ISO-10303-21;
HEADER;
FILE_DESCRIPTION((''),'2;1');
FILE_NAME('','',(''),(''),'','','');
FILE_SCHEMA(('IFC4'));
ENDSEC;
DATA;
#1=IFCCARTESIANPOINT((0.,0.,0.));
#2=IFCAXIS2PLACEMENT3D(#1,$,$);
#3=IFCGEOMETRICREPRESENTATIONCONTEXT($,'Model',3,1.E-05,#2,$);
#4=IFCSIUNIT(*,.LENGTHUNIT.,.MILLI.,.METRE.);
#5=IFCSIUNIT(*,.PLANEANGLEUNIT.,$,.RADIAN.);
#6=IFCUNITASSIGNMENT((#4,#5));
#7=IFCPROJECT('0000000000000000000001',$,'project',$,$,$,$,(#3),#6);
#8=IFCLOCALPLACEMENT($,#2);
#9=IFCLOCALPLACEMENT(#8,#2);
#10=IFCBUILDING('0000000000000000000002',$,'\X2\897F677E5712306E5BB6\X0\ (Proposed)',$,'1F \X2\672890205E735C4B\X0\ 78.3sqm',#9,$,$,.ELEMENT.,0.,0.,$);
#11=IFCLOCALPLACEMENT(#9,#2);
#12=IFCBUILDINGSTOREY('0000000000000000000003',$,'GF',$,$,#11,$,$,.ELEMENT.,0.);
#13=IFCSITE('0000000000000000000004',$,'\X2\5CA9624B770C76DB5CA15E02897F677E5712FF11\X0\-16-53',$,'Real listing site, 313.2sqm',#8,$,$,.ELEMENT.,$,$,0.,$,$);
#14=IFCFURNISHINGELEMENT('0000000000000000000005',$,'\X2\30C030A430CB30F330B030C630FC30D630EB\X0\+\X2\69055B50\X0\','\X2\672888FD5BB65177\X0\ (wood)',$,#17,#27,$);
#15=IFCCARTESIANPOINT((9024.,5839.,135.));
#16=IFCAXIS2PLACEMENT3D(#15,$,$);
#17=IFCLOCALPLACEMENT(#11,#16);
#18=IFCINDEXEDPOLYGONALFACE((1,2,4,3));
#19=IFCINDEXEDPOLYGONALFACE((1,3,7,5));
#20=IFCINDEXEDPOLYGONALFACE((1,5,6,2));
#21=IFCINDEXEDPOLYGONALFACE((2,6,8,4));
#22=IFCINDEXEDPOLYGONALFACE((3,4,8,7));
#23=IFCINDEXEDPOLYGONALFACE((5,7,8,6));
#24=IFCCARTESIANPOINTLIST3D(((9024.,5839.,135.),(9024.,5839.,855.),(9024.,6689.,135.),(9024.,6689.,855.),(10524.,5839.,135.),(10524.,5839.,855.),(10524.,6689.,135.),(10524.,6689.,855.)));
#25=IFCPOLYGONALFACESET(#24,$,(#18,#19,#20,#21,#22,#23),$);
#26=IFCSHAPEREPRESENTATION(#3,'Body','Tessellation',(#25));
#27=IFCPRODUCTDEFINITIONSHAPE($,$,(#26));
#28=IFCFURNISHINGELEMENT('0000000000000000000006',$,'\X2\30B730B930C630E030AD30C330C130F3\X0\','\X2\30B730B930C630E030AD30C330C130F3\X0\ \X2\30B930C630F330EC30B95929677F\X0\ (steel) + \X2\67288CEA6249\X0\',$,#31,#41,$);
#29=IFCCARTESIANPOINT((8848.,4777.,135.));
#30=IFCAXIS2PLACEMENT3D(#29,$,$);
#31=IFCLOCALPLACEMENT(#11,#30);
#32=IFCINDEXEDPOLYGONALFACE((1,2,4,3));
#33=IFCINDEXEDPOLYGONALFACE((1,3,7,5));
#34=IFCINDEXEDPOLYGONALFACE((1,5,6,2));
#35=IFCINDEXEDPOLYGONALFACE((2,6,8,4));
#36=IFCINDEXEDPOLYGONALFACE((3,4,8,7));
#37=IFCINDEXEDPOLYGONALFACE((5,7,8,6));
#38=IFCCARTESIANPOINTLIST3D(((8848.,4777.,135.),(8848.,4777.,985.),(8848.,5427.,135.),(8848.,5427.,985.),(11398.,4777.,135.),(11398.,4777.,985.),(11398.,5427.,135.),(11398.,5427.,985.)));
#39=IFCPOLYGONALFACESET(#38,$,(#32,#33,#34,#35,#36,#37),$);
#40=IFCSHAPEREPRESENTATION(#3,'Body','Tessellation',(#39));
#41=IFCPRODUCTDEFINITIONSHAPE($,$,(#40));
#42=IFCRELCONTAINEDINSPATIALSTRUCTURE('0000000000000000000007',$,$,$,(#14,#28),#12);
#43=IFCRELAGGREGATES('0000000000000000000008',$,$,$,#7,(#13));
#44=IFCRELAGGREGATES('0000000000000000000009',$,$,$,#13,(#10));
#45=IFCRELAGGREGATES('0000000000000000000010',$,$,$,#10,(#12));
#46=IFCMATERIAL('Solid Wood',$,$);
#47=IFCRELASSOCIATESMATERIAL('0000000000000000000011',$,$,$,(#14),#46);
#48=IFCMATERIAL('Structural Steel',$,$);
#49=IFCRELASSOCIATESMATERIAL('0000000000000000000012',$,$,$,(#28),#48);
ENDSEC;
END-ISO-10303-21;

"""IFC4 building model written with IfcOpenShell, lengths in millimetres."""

from ifc_helpers import new_model, si_unit, frame, frame_2d, origin, place, context, project, spatial, rectangle, extrude, material, element, save


model = new_model("IFC4")

# Units and contexts
model_context = context("Model", 3, precision=1e-05, world=origin())
ifc_project = project(units=[si_unit("LENGTHUNIT", "METRE", prefix="MILLI"), si_unit("PLANEANGLEUNIT", "RADIAN")], contexts=[model_context])

# Site, building, storey
site_placement = place(None, origin())
site = spatial("IfcSite", under=ifc_project, at=site_placement, Name="岩手県盛岡市西松園１-16-53", ObjectType="Real listing site, 313.2sqm", CompositionType="ELEMENT", RefElevation=0.0)
building_placement = place(site_placement, origin())
building = spatial("IfcBuilding", under=site, at=building_placement, Name="西松園の家 (Proposed)", ObjectType="1F 木造平屋 78.3sqm", CompositionType="ELEMENT", ElevationOfRefHeight=0.0, ElevationOfTerrain=0.0)
storey_placement = place(building_placement, origin())
storey = spatial("IfcBuildingStorey", under=building, at=storey_placement, Name="GF", CompositionType="ELEMENT", Elevation=0.0)

# Shared definitions
ifc_material_1 = material(Name="Solid Wood")

# Shared definitions
ifc_material_2 = material(Name="Structural Steel")

# Furnishing elements
furnishing_1_placement = place(storey_placement, frame((9024.0, 5839.0, 135.0)))
element("IfcFurnishingElement", 1, at=furnishing_1_placement, inside=storey, material=ifc_material_1, Name="ダイニングテーブル+椅子", Description="木製家具 (wood)", context=model_context, shape_type="SweptSolid", body=[
    extrude(rectangle(XDim=1500.0, YDim=850.0, at=frame_2d((750.0, 425.0))), frame((9024.0, 5839.0, 135.0)), (0.0, 0.0, 1.0), 720.0),
])
furnishing_2_placement = place(storey_placement, frame((8848.0, 4777.0, 135.0)))
element("IfcFurnishingElement", 2, at=furnishing_2_placement, inside=storey, material=ifc_material_2, Name="システムキッチン", Description="システムキッチン ステンレス天板 (steel) + 木質扉", context=model_context, shape_type="SweptSolid", body=[
    extrude(rectangle(XDim=2550.0, YDim=650.0, at=frame_2d((1275.0, 325.0))), frame((8848.0, 4777.0, 135.0)), (0.0, 0.0, 1.0), 850.0),
])

save(model, "model.ifc")
